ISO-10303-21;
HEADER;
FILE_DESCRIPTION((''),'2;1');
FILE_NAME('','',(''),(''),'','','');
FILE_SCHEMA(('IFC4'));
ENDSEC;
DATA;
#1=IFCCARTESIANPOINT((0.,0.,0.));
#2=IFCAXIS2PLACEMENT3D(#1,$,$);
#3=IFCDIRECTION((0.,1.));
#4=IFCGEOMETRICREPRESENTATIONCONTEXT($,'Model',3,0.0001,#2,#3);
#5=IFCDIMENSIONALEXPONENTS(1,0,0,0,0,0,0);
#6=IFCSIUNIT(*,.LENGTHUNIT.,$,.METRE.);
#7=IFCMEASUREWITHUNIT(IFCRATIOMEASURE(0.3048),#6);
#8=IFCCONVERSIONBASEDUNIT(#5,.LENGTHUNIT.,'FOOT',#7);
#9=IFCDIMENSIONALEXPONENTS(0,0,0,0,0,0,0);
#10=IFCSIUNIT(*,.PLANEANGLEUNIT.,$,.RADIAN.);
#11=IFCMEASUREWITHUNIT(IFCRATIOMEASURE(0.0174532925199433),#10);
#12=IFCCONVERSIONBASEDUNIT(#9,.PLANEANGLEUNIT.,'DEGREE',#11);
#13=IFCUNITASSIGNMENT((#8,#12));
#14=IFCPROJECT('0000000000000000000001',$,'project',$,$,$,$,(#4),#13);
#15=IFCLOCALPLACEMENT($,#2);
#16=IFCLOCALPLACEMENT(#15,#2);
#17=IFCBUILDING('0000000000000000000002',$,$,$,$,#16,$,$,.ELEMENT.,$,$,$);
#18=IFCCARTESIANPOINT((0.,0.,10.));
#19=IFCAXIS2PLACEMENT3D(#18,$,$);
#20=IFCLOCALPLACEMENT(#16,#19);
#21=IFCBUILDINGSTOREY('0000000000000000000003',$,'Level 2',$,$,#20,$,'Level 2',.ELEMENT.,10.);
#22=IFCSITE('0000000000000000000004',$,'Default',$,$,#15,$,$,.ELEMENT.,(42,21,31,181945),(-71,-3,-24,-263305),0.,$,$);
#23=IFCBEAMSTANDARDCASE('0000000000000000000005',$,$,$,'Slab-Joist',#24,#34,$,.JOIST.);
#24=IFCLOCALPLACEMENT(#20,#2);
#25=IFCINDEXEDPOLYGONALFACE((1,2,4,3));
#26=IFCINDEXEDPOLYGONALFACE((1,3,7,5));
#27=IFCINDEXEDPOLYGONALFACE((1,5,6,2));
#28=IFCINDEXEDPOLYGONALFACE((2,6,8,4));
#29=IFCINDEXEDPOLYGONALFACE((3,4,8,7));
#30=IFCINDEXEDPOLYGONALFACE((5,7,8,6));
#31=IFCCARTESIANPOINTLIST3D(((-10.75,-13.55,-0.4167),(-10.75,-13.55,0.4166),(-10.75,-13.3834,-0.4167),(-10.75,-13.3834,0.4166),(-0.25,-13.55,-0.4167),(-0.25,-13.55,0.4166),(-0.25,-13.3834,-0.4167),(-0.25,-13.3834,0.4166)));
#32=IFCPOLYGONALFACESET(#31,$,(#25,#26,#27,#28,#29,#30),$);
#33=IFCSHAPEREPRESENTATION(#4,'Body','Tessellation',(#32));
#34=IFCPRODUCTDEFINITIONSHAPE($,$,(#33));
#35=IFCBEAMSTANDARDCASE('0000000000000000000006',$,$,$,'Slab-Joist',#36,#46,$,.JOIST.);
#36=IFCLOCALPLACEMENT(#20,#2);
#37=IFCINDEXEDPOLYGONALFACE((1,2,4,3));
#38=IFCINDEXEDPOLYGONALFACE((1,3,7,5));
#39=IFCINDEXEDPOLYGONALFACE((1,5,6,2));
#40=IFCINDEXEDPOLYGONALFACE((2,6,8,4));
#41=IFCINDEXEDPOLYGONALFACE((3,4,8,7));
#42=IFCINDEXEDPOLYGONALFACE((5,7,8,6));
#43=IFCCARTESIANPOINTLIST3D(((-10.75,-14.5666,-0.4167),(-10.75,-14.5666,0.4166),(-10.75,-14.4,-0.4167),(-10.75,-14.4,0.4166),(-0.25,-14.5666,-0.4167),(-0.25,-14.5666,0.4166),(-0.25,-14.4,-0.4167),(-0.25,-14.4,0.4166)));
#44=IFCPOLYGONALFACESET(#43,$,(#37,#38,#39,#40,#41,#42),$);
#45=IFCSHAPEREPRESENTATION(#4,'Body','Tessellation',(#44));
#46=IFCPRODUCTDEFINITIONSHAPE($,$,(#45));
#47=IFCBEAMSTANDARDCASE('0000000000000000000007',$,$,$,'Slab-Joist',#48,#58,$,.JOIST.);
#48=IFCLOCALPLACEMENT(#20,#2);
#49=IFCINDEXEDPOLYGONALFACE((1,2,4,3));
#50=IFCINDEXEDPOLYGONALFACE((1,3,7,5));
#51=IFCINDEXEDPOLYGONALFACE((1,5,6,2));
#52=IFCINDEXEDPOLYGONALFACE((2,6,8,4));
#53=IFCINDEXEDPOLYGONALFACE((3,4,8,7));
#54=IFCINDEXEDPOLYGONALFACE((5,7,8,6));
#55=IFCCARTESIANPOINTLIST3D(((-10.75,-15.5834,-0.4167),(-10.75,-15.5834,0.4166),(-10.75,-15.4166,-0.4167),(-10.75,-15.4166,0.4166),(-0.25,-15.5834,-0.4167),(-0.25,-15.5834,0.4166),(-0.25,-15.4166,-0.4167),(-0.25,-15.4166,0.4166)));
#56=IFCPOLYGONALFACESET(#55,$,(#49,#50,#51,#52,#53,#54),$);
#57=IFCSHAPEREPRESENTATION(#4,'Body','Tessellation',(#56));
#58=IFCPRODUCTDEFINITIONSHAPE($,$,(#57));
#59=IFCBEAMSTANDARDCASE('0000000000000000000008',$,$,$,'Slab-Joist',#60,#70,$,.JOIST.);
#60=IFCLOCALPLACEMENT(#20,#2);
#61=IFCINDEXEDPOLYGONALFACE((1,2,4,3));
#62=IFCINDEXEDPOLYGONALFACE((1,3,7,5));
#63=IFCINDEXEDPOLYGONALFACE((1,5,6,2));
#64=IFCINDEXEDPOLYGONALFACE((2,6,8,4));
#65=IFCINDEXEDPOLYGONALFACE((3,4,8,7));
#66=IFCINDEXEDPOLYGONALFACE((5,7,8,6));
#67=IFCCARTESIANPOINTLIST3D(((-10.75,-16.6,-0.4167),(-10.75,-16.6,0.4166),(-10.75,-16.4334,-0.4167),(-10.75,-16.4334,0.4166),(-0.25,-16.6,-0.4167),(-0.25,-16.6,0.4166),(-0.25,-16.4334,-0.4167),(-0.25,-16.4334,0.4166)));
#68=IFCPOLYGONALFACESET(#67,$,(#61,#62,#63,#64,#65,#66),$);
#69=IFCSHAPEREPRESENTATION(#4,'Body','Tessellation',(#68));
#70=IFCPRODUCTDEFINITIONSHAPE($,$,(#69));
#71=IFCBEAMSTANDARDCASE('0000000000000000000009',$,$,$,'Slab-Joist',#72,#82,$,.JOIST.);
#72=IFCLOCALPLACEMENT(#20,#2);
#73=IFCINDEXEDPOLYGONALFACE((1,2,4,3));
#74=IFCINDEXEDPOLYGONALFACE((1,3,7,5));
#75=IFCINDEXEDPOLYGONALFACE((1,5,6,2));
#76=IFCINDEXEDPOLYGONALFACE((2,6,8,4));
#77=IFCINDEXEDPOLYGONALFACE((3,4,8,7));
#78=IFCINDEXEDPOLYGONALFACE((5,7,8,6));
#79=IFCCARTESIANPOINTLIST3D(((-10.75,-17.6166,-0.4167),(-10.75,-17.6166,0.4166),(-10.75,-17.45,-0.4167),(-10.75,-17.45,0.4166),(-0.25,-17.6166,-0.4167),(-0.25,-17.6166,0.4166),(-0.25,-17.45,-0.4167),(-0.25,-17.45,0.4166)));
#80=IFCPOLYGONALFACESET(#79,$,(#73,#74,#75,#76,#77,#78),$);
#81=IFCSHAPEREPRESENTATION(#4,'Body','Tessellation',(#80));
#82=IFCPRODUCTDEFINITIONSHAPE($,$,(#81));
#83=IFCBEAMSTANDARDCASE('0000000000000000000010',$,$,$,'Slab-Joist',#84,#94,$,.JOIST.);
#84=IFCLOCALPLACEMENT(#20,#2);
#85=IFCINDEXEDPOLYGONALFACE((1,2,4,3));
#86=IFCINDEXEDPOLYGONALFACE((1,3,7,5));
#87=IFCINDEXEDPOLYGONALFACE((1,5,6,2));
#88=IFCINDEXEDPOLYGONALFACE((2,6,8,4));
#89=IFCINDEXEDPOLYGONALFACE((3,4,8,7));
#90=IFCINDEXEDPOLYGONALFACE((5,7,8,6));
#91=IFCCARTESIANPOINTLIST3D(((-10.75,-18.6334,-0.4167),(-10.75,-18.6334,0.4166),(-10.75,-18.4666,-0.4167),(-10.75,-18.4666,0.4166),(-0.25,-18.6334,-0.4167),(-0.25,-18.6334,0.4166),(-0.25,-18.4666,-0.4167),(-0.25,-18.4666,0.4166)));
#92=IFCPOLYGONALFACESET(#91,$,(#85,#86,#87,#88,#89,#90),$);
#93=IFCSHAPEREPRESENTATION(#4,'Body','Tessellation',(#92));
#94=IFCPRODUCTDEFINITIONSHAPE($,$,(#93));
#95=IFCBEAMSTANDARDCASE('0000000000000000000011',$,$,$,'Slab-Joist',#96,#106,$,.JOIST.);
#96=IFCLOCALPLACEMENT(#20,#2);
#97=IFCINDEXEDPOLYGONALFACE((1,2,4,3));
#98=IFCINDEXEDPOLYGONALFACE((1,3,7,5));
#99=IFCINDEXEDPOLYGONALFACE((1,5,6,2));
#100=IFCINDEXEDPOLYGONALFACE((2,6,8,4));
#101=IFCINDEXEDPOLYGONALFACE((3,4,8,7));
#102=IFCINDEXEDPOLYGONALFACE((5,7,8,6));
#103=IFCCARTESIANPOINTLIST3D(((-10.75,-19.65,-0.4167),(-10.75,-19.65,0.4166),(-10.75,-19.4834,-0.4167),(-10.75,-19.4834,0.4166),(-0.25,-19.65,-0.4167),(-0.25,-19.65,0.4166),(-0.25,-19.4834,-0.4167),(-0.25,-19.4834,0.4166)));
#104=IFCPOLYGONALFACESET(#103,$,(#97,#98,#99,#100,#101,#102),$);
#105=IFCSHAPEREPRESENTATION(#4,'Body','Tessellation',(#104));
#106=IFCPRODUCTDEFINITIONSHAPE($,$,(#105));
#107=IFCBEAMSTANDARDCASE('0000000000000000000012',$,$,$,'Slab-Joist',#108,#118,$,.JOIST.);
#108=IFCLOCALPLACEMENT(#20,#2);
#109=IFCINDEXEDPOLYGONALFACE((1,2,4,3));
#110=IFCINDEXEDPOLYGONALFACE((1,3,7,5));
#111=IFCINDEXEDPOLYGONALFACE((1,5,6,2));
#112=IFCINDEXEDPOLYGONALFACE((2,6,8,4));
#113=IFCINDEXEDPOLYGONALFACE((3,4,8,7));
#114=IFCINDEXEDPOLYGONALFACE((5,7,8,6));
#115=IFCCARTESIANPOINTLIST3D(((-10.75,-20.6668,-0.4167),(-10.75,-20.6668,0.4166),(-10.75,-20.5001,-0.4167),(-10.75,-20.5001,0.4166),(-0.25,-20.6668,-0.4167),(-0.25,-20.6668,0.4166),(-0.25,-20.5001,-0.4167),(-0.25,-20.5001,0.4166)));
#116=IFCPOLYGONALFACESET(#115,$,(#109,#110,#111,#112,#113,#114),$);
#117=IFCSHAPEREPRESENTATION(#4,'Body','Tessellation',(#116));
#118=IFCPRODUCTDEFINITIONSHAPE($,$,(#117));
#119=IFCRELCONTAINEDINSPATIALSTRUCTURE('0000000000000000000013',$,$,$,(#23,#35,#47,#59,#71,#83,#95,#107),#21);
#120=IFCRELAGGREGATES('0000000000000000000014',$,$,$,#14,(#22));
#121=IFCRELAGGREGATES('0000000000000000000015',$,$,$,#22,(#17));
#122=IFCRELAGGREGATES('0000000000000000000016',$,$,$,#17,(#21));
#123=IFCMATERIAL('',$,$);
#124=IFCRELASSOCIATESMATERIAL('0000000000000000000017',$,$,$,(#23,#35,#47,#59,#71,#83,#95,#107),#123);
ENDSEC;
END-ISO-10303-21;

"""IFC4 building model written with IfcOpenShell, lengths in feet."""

from ifc_helpers import new_model, entity, si_unit, converted_unit, direction, frame, origin, origin_with_axes, place, context, project, spatial, rectangle, extrude, material, element, save


model = new_model("IFC4")

# Units and contexts
model_context = context("Model", 3, precision=0.0001, world=origin(), true_north=direction((0.0, 1.0)))
ifc_project = project(units=[converted_unit("LENGTHUNIT", "FOOT", entity("IfcRatioMeasure", 0.3048), si_unit("LENGTHUNIT", "METRE"), dimensions=[1, 0, 0, 0, 0, 0, 0]), converted_unit("PLANEANGLEUNIT", "DEGREE", entity("IfcRatioMeasure", 0.0174532925199433), si_unit("PLANEANGLEUNIT", "RADIAN"), dimensions=[0, 0, 0, 0, 0, 0, 0])], contexts=[model_context])

# Site, building, storey
site_placement = place(None, origin())
site = spatial("IfcSite", under=ifc_project, at=site_placement, Name="Default", CompositionType="ELEMENT", RefLatitude=(42, 21, 31, 181945), RefLongitude=(-71, -3, -24, -263305), RefElevation=0.0)
building_placement = place(site_placement, origin())
building = spatial("IfcBuilding", under=site, at=building_placement, CompositionType="ELEMENT")
storey_placement = place(building_placement, frame((0.0, 0.0, 10.0)))
storey = spatial("IfcBuildingStorey", under=building, at=storey_placement, Name="Level 2", LongName="Level 2", CompositionType="ELEMENT", Elevation=10.0)

# Beams
ifc_material = material(Name="")
placement_1 = place(storey_placement, frame((-0.25, -0.25, 0.0), z_axis=(0.0, 0.0, 1.0), x_axis=(1.0, 0.0, 0.0)))
beam_1_placement = place(placement_1, frame((0.0, -13.2167, 0.0), z_axis=(-1.0, 0.0, 0.0), x_axis=(0.0, -1.0, 0.0)))
element("IfcBeamStandardCase", 1, at=beam_1_placement, inside=storey, material=ifc_material, ObjectType="Slab-Joist", PredefinedType="JOIST", context=model_context, shape_type="SweptSolid", body=[
    extrude(rectangle(XDim=0.1667, YDim=0.8333), origin_with_axes(), (0.0, 0.0, 1.0), 10.5),
])
placement_2 = place(storey_placement, frame((-0.25, -0.25, 0.0), z_axis=(0.0, 0.0, 1.0), x_axis=(1.0, 0.0, 0.0)))
beam_2_placement = place(placement_2, frame((0.0, -14.2333, 0.0), z_axis=(-1.0, 0.0, 0.0), x_axis=(0.0, -1.0, 0.0)))
element("IfcBeamStandardCase", 2, at=beam_2_placement, inside=storey, material=ifc_material, ObjectType="Slab-Joist", PredefinedType="JOIST", context=model_context, shape_type="SweptSolid", body=[
    extrude(rectangle(XDim=0.1667, YDim=0.8333), origin_with_axes(), (0.0, 0.0, 1.0), 10.5),
])
placement_3 = place(storey_placement, frame((-0.25, -0.25, 0.0), z_axis=(0.0, 0.0, 1.0), x_axis=(1.0, 0.0, 0.0)))
beam_3_placement = place(placement_3, frame((0.0, -15.25, 0.0), z_axis=(-1.0, 0.0, 0.0), x_axis=(0.0, -1.0, 0.0)))
element("IfcBeamStandardCase", 3, at=beam_3_placement, inside=storey, material=ifc_material, ObjectType="Slab-Joist", PredefinedType="JOIST", context=model_context, shape_type="SweptSolid", body=[
    extrude(rectangle(XDim=0.1667, YDim=0.8333), origin_with_axes(), (0.0, 0.0, 1.0), 10.5),
])
placement_4 = place(storey_placement, frame((-0.25, -0.25, 0.0), z_axis=(0.0, 0.0, 1.0), x_axis=(1.0, 0.0, 0.0)))
beam_4_placement = place(placement_4, frame((0.0, -16.2667, 0.0), z_axis=(-1.0, 0.0, 0.0), x_axis=(0.0, -1.0, 0.0)))
element("IfcBeamStandardCase", 4, at=beam_4_placement, inside=storey, material=ifc_material, ObjectType="Slab-Joist", PredefinedType="JOIST", context=model_context, shape_type="SweptSolid", body=[
    extrude(rectangle(XDim=0.1667, YDim=0.8333), origin_with_axes(), (0.0, 0.0, 1.0), 10.5),
])
placement_5 = place(storey_placement, frame((-0.25, -0.25, 0.0), z_axis=(0.0, 0.0, 1.0), x_axis=(1.0, 0.0, 0.0)))
beam_5_placement = place(placement_5, frame((0.0, -17.2833, 0.0), z_axis=(-1.0, 0.0, 0.0), x_axis=(0.0, -1.0, 0.0)))
element("IfcBeamStandardCase", 5, at=beam_5_placement, inside=storey, material=ifc_material, ObjectType="Slab-Joist", PredefinedType="JOIST", context=model_context, shape_type="SweptSolid", body=[
    extrude(rectangle(XDim=0.1667, YDim=0.8333), origin_with_axes(), (0.0, 0.0, 1.0), 10.5),
])
placement_6 = place(storey_placement, frame((-0.25, -0.25, 0.0), z_axis=(0.0, 0.0, 1.0), x_axis=(1.0, 0.0, 0.0)))
beam_6_placement = place(placement_6, frame((0.0, -18.3, 0.0), z_axis=(-1.0, 0.0, 0.0), x_axis=(0.0, -1.0, 0.0)))
element("IfcBeamStandardCase", 6, at=beam_6_placement, inside=storey, material=ifc_material, ObjectType="Slab-Joist", PredefinedType="JOIST", context=model_context, shape_type="SweptSolid", body=[
    extrude(rectangle(XDim=0.1667, YDim=0.8333), origin_with_axes(), (0.0, 0.0, 1.0), 10.5),
])
placement_7 = place(storey_placement, frame((-0.25, -0.25, 0.0), z_axis=(0.0, 0.0, 1.0), x_axis=(1.0, 0.0, 0.0)))
beam_7_placement = place(placement_7, frame((0.0, -19.3167, 0.0), z_axis=(-1.0, 0.0, 0.0), x_axis=(0.0, -1.0, 0.0)))
element("IfcBeamStandardCase", 7, at=beam_7_placement, inside=storey, material=ifc_material, ObjectType="Slab-Joist", PredefinedType="JOIST", context=model_context, shape_type="SweptSolid", body=[
    extrude(rectangle(XDim=0.1667, YDim=0.8333), origin_with_axes(), (0.0, 0.0, 1.0), 10.5),
])
placement_8 = place(storey_placement, frame((-0.25, -0.25, 0.0), z_axis=(0.0, 0.0, 1.0), x_axis=(1.0, 0.0, 0.0)))
beam_8_placement = place(placement_8, frame((0.0, -20.3334, 0.0), z_axis=(-1.0, 0.0, 0.0), x_axis=(0.0, -1.0, 0.0)))
element("IfcBeamStandardCase", 8, at=beam_8_placement, inside=storey, material=ifc_material, ObjectType="Slab-Joist", PredefinedType="JOIST", context=model_context, shape_type="SweptSolid", body=[
    extrude(rectangle(XDim=0.1667, YDim=0.8333), origin_with_axes(), (0.0, 0.0, 1.0), 10.5),
])

save(model, "model.ifc")
